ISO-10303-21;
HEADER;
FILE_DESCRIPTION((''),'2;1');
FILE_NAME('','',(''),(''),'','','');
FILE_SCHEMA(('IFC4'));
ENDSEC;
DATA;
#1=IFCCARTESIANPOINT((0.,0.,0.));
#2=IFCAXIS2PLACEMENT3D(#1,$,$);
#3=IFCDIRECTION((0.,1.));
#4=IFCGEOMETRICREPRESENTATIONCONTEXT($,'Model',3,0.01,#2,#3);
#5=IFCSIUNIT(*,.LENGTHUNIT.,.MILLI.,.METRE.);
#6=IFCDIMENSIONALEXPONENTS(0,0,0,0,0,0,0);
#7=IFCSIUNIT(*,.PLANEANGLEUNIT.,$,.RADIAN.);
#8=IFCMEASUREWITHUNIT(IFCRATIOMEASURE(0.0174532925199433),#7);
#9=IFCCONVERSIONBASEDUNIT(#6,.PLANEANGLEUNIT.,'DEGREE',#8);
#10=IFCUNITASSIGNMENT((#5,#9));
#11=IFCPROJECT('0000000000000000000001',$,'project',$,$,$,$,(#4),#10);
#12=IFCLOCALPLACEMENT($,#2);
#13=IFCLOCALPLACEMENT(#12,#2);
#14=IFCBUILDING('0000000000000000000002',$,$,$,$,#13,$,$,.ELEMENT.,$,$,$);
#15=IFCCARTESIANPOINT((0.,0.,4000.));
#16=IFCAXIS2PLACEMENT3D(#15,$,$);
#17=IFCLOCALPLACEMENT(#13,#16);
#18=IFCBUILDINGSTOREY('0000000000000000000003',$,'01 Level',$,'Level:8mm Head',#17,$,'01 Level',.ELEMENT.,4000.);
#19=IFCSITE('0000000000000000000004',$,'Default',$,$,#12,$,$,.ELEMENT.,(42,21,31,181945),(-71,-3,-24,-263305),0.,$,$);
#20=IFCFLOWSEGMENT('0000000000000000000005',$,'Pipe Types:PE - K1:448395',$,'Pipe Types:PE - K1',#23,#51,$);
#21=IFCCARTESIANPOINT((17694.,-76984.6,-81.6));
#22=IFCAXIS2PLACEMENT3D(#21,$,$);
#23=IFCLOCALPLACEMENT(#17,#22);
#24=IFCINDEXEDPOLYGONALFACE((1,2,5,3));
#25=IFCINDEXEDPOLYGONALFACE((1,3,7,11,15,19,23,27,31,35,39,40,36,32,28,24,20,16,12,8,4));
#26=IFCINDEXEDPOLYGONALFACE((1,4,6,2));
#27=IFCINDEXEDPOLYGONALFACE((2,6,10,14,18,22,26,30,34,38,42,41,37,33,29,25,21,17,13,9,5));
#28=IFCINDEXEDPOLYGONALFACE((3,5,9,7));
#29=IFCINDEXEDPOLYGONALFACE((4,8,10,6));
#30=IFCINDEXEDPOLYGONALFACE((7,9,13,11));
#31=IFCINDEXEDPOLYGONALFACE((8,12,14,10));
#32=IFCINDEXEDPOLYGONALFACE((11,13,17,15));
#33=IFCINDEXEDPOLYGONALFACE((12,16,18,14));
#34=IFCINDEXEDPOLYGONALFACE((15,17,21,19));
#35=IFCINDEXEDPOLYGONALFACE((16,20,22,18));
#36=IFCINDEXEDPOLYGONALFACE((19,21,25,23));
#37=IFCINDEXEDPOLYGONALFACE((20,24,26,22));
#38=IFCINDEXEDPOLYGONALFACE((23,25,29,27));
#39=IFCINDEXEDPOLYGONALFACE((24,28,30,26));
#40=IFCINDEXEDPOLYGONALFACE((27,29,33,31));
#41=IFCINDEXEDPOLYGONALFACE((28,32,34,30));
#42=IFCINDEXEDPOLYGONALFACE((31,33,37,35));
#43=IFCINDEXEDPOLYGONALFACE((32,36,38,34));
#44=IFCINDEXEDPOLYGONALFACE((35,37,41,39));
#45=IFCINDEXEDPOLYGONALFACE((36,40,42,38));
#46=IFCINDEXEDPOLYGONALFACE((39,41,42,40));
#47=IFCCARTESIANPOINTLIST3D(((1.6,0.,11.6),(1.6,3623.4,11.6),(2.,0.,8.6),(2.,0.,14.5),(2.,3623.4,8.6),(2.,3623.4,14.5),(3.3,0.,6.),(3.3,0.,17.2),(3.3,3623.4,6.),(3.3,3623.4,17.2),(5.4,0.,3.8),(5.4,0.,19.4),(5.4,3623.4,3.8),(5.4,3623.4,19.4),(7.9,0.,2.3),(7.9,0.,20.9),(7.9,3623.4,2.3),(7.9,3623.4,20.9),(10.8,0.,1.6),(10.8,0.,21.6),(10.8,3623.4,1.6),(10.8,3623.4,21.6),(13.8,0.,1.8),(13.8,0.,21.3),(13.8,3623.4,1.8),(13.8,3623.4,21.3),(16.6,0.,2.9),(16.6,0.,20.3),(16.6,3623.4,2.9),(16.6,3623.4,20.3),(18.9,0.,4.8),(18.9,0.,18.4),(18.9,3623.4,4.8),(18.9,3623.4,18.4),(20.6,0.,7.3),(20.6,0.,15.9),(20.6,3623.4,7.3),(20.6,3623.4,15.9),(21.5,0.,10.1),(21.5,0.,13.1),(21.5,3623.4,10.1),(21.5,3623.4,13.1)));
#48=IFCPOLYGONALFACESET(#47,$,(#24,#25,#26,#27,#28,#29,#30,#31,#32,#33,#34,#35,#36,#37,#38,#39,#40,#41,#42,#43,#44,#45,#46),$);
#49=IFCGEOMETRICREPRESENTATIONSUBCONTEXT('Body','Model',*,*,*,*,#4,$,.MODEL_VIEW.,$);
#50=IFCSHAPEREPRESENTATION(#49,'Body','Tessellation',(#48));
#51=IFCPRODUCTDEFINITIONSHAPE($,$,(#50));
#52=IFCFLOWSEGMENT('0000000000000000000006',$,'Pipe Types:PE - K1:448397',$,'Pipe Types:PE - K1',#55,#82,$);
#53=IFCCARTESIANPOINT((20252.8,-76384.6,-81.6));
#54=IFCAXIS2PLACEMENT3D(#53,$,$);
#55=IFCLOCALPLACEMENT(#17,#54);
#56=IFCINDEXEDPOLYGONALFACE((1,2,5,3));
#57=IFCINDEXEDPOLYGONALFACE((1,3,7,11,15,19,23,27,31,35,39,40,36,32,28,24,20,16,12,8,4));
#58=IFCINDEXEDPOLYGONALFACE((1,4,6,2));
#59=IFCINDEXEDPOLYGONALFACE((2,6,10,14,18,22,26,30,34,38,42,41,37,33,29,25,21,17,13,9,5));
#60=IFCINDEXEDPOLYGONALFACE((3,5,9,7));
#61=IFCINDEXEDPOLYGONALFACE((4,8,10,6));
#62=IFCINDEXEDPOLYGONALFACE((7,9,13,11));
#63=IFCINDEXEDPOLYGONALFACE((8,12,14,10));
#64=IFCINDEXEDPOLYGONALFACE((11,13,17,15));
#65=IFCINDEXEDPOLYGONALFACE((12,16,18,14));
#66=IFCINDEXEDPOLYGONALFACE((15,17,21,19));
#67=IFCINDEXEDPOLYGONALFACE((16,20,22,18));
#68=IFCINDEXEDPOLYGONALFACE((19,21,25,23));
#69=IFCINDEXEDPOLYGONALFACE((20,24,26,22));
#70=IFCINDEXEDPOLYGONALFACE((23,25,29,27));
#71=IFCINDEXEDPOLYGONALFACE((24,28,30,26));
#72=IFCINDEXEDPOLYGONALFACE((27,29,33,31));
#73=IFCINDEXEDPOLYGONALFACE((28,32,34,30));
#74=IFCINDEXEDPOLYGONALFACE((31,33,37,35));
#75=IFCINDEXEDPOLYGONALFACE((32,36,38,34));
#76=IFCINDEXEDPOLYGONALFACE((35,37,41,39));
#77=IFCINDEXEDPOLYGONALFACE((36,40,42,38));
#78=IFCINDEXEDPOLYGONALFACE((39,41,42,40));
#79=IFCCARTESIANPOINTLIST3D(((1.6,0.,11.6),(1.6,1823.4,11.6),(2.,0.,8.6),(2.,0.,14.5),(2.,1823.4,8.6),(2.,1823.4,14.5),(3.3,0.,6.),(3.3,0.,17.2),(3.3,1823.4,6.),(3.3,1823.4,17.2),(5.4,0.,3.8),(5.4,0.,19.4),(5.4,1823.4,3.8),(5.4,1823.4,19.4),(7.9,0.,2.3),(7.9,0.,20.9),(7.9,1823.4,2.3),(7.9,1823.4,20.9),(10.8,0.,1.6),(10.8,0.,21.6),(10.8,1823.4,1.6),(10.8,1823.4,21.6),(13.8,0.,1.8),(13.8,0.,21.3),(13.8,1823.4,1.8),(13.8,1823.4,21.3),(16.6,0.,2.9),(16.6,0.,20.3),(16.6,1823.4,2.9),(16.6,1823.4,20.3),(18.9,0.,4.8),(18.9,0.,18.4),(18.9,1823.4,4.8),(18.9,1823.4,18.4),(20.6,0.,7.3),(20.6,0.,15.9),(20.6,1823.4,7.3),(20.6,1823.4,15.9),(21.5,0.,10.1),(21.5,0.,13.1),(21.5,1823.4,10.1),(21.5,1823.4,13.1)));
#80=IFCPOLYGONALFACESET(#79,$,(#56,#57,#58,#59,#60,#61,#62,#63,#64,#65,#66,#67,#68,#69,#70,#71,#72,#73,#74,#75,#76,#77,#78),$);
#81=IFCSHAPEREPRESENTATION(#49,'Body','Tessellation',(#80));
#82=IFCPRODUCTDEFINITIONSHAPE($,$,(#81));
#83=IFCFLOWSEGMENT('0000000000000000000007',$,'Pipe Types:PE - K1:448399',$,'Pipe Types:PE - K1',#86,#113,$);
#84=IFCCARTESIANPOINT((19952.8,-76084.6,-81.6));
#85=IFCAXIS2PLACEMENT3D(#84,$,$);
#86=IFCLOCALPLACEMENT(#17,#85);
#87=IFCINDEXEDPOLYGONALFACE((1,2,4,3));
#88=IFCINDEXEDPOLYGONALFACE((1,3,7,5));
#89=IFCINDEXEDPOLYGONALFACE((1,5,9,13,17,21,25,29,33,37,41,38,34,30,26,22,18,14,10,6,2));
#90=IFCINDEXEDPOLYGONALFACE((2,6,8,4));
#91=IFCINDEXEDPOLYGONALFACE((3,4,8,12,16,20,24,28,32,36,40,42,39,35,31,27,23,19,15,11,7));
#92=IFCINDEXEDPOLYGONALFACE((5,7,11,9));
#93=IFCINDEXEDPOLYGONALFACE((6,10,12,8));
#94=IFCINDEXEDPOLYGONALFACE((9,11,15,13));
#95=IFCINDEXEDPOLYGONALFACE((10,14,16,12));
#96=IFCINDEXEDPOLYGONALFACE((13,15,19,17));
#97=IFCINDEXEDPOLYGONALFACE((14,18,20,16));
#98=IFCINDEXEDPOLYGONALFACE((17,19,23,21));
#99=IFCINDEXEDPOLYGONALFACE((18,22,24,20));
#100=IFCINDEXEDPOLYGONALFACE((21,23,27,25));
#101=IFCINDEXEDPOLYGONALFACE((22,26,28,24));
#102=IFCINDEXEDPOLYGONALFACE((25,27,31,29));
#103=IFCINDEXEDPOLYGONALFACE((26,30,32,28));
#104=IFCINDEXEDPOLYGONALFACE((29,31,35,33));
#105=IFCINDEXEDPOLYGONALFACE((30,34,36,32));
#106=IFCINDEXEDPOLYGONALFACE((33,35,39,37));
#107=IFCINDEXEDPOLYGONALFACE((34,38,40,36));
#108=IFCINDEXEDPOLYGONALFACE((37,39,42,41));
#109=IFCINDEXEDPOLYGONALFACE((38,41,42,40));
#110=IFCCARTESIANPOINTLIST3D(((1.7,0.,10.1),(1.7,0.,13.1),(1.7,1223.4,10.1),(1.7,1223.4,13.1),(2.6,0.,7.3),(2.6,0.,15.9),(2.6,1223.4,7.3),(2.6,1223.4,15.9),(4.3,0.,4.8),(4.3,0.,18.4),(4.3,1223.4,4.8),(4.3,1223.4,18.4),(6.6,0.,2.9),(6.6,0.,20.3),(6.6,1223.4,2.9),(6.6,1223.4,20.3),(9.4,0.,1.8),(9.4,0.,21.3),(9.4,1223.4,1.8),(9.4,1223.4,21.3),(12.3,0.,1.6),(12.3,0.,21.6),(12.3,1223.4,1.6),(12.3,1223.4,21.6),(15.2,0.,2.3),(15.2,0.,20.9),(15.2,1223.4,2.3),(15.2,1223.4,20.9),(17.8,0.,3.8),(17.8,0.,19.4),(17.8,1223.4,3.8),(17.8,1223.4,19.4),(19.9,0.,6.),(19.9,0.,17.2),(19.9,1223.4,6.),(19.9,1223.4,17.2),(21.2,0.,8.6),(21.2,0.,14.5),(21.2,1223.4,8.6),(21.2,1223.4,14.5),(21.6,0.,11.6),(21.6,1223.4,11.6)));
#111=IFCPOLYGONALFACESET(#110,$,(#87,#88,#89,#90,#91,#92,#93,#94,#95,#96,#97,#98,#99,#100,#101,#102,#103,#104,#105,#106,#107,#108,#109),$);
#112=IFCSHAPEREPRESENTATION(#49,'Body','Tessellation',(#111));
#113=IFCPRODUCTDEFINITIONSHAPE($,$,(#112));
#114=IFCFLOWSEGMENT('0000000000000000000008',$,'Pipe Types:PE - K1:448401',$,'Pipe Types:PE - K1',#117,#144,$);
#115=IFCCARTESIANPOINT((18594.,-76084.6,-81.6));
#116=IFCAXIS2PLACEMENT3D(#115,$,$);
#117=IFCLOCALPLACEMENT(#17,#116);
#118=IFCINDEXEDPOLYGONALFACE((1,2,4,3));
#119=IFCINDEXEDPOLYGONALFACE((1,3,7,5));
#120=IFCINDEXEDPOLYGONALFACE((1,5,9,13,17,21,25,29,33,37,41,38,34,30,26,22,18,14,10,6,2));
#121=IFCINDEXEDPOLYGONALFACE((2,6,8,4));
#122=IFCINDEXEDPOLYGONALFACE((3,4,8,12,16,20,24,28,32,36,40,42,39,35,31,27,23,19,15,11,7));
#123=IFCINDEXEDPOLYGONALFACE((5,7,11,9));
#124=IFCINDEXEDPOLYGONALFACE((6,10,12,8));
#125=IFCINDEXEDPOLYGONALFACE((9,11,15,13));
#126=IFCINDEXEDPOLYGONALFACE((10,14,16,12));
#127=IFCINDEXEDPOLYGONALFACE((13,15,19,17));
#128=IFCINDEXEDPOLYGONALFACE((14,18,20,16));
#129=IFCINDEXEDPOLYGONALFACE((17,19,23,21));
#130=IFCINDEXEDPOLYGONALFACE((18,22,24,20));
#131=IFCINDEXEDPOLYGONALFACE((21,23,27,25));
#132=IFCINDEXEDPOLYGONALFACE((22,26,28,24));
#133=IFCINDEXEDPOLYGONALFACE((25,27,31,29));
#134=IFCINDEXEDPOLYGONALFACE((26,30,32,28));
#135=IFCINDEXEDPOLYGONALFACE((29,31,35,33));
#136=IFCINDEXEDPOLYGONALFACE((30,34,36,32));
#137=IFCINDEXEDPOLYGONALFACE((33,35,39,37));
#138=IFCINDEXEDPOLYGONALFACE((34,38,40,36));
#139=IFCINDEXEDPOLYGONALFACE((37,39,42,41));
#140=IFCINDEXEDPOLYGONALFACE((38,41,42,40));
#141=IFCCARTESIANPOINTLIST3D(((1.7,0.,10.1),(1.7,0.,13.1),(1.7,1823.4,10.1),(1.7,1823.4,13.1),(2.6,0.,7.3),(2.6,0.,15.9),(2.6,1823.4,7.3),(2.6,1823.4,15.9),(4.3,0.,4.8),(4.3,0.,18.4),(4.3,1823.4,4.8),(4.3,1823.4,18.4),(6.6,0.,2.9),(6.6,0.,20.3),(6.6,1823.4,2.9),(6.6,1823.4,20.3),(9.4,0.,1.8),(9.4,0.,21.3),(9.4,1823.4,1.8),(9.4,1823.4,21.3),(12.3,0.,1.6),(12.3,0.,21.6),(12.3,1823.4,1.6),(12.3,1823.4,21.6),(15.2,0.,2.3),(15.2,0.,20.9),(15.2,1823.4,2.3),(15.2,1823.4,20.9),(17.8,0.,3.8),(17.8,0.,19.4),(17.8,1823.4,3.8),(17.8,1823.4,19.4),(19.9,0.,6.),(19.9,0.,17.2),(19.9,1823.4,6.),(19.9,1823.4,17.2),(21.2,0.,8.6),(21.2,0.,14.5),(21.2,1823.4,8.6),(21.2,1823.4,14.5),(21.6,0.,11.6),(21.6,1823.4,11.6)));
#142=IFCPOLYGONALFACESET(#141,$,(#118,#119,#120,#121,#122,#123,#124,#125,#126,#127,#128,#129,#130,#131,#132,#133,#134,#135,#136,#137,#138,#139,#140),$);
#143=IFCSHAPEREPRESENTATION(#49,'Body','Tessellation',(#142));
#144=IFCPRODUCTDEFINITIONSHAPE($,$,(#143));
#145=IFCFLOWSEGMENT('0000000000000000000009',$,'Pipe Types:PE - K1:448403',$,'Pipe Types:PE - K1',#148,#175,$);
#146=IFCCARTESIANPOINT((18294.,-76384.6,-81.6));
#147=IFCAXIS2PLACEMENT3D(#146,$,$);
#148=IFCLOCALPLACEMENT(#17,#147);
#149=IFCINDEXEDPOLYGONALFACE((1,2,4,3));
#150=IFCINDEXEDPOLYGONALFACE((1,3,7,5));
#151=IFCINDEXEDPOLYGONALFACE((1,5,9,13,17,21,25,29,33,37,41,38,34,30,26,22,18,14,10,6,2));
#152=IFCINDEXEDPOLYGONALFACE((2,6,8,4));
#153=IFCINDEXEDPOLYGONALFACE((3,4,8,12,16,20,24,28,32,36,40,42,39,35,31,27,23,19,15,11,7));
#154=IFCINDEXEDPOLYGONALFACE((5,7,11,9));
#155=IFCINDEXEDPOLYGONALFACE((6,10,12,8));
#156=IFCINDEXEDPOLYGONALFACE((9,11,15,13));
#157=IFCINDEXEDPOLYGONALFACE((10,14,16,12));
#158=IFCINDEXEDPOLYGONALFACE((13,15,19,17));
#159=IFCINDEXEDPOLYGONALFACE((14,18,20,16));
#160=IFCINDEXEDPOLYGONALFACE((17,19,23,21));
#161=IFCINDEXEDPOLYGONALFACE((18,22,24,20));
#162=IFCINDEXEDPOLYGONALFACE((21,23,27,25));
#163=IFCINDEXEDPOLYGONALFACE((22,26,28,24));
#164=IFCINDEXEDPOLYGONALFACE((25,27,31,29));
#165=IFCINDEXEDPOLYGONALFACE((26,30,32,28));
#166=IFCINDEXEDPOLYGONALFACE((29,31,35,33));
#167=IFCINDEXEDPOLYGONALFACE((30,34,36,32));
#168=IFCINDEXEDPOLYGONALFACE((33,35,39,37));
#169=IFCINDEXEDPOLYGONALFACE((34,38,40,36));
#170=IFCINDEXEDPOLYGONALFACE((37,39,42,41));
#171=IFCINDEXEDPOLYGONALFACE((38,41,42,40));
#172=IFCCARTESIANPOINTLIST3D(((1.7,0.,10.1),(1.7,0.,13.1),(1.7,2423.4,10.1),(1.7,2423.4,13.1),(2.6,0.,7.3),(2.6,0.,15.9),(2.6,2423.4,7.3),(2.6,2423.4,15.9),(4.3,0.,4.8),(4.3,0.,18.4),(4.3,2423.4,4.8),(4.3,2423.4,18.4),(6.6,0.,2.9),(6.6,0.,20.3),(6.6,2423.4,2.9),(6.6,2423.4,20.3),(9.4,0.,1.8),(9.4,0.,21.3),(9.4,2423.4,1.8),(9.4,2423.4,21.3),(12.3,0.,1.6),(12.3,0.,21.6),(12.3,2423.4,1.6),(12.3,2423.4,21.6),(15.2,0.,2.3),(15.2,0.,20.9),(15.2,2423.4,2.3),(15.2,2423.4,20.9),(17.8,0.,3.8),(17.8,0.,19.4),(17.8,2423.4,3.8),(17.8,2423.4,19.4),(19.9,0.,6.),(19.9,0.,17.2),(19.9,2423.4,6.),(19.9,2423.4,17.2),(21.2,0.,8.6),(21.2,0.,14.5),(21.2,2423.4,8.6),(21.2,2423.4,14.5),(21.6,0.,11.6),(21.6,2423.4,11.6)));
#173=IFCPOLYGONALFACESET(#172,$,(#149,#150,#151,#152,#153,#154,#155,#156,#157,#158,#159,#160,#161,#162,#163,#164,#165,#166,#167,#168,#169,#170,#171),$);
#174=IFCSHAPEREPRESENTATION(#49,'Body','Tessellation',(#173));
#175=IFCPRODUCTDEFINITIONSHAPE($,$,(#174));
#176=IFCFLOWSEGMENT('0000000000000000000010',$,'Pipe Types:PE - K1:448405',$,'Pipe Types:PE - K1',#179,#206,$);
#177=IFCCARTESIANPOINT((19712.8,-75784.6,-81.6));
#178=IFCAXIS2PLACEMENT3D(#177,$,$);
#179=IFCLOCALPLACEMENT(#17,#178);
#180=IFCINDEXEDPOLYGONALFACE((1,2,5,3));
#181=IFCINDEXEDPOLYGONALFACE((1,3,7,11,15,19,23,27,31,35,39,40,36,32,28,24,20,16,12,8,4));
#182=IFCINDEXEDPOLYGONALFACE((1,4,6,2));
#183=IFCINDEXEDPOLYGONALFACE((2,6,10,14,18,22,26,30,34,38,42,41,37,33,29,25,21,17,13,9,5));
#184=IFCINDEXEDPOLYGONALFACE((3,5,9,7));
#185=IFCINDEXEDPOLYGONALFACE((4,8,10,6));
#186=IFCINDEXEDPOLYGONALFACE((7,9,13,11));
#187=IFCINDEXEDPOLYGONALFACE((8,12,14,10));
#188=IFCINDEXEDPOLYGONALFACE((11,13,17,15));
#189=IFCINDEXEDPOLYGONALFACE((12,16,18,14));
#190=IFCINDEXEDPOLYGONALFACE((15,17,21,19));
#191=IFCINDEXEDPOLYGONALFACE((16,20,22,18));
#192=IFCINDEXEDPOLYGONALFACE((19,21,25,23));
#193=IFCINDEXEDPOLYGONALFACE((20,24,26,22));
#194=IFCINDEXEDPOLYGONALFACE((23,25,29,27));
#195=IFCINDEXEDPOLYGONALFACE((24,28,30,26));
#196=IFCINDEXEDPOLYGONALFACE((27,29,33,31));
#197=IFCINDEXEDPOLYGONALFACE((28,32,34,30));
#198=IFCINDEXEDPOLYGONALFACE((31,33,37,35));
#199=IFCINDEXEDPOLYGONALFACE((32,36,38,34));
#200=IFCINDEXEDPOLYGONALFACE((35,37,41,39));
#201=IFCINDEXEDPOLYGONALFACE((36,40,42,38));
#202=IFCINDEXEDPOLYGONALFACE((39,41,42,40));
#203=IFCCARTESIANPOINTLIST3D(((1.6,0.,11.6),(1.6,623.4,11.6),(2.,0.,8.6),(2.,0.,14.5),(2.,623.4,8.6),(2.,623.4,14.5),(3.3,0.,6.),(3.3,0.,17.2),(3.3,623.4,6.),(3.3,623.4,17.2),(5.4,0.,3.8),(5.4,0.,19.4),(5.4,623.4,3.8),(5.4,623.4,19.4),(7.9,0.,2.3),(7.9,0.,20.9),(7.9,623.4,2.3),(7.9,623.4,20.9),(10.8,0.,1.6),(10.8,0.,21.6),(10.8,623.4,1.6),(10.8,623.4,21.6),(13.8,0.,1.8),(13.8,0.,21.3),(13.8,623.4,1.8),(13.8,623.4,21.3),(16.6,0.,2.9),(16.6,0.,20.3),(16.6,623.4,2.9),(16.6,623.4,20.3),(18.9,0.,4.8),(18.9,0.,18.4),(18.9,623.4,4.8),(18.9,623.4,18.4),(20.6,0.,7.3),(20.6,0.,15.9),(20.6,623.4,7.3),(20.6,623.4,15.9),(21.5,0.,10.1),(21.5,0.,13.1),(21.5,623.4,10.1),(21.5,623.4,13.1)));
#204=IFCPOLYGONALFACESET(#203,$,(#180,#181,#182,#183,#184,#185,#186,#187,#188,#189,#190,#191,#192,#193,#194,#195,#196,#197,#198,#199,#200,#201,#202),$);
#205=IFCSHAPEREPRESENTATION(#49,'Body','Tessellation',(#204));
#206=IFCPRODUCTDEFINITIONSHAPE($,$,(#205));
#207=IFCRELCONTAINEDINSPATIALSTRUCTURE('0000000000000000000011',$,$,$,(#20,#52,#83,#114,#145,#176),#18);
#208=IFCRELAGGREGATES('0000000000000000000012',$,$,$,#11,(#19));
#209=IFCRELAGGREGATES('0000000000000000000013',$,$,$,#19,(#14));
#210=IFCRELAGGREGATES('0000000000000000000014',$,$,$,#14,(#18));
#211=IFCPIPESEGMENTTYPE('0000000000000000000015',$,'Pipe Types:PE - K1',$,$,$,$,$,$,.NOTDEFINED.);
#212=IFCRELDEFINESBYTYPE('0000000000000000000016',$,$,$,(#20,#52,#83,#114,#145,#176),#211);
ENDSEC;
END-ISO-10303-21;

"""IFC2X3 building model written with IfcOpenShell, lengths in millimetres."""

from ifc_helpers import new_model, entity, si_unit, converted_unit, direction, frame, frame_2d, origin, origin_2d_with_axis, place, context, subcontext, project, spatial, circle, extrude, type_object, element, save


model = new_model("IFC2X3")

# Units and contexts
model_context = context("Model", 3, precision=0.01, world=origin(), true_north=direction((0.0, 1.0)))
body_context = subcontext(model_context, "Body", "Model", "MODEL_VIEW")
ifc_project = project(units=[si_unit("LENGTHUNIT", "METRE", prefix="MILLI"), converted_unit("PLANEANGLEUNIT", "DEGREE", entity("IfcRatioMeasure", 0.0174532925199433), si_unit("PLANEANGLEUNIT", "RADIAN"), dimensions=[0, 0, 0, 0, 0, 0, 0])], contexts=[model_context])

# Site, building, storey
site_placement = place(None, origin())
site = spatial("IfcSite", under=ifc_project, at=site_placement, Name="Default", CompositionType="ELEMENT", RefLatitude=(42, 21, 31, 181945), RefLongitude=(-71, -3, -24, -263305), RefElevation=0.0)
building_placement = place(site_placement, origin())
building = spatial("IfcBuilding", under=site, at=building_placement, CompositionType="ELEMENT")
storey_placement = place(building_placement, frame((0.0, 0.0, 4000.0)))
storey = spatial("IfcBuildingStorey", under=building, at=storey_placement, Name="01 Level", ObjectType="Level:8mm Head", LongName="01 Level", CompositionType="ELEMENT", Elevation=4000.0)

# Flow segments
pipe_segment_type = type_object("IfcPipeSegmentType", Name="Pipe Types:PE - K1", PredefinedType="NOTDEFINED")
flow_segment_1_placement = place(storey_placement, frame((17694.0, -76984.6, -81.6)))
element("IfcFlowSegment", 1, at=flow_segment_1_placement, inside=storey, type_object=pipe_segment_type, Name="Pipe Types:PE - K1:448395", ObjectType="Pipe Types:PE - K1", context=body_context, shape_type="SweptSolid", body=[
    extrude(circle(Radius=10.0, at=frame_2d((0.0, 0.0), x_axis=(1.0, 0.0))), frame((11.6, 0.0, 11.6), z_axis=(0.0, 1.0, 0.0), x_axis=(-1.0, 0.0, 0.0)), (0.0, 0.0, 1.0), 3623.4),
])
flow_segment_2_placement = place(storey_placement, frame((20252.8, -76384.6, -81.6)))
element("IfcFlowSegment", 2, at=flow_segment_2_placement, inside=storey, type_object=pipe_segment_type, Name="Pipe Types:PE - K1:448397", ObjectType="Pipe Types:PE - K1", context=body_context, shape_type="SweptSolid", body=[
    extrude(circle(Radius=10.0, at=frame_2d((0.0, 0.0), x_axis=(1.0, 0.0))), frame((11.6, 0.0, 11.6), z_axis=(0.0, 1.0, 0.0), x_axis=(-1.0, 0.0, 0.0)), (0.0, 0.0, 1.0), 1823.4),
])
flow_segment_3_placement = place(storey_placement, frame((19952.8, -76084.6, -81.6)))
element("IfcFlowSegment", 3, at=flow_segment_3_placement, inside=storey, type_object=pipe_segment_type, Name="Pipe Types:PE - K1:448399", ObjectType="Pipe Types:PE - K1", context=body_context, shape_type="SweptSolid", body=[
    extrude(circle(Radius=10.0, at=origin_2d_with_axis()), frame((11.6, 0.0, 11.6), z_axis=(0.0, 1.0, 0.0), x_axis=(1.0, 0.0, 0.0)), (0.0, 0.0, 1.0), 1223.4),
])
flow_segment_4_placement = place(storey_placement, frame((18594.0, -76084.6, -81.6)))
element("IfcFlowSegment", 4, at=flow_segment_4_placement, inside=storey, type_object=pipe_segment_type, Name="Pipe Types:PE - K1:448401", ObjectType="Pipe Types:PE - K1", context=body_context, shape_type="SweptSolid", body=[
    extrude(circle(Radius=10.0, at=origin_2d_with_axis()), frame((11.6, 0.0, 11.6), z_axis=(0.0, 1.0, 0.0), x_axis=(1.0, 0.0, 0.0)), (0.0, 0.0, 1.0), 1823.4),
])
flow_segment_5_placement = place(storey_placement, frame((18294.0, -76384.6, -81.6)))
element("IfcFlowSegment", 5, at=flow_segment_5_placement, inside=storey, type_object=pipe_segment_type, Name="Pipe Types:PE - K1:448403", ObjectType="Pipe Types:PE - K1", context=body_context, shape_type="SweptSolid", body=[
    extrude(circle(Radius=10.0, at=origin_2d_with_axis()), frame((11.6, 0.0, 11.6), z_axis=(0.0, 1.0, 0.0), x_axis=(1.0, 0.0, 0.0)), (0.0, 0.0, 1.0), 2423.4),
])
flow_segment_6_placement = place(storey_placement, frame((19712.8, -75784.6, -81.6)))
element("IfcFlowSegment", 6, at=flow_segment_6_placement, inside=storey, type_object=pipe_segment_type, Name="Pipe Types:PE - K1:448405", ObjectType="Pipe Types:PE - K1", context=body_context, shape_type="SweptSolid", body=[
    extrude(circle(Radius=10.0, at=frame_2d((0.0, 0.0), x_axis=(1.0, 0.0))), frame((11.6, 0.0, 11.6), z_axis=(0.0, 1.0, 0.0), x_axis=(-1.0, 0.0, 0.0)), (0.0, 0.0, 1.0), 623.4),
])

save(model, "model.ifc")
